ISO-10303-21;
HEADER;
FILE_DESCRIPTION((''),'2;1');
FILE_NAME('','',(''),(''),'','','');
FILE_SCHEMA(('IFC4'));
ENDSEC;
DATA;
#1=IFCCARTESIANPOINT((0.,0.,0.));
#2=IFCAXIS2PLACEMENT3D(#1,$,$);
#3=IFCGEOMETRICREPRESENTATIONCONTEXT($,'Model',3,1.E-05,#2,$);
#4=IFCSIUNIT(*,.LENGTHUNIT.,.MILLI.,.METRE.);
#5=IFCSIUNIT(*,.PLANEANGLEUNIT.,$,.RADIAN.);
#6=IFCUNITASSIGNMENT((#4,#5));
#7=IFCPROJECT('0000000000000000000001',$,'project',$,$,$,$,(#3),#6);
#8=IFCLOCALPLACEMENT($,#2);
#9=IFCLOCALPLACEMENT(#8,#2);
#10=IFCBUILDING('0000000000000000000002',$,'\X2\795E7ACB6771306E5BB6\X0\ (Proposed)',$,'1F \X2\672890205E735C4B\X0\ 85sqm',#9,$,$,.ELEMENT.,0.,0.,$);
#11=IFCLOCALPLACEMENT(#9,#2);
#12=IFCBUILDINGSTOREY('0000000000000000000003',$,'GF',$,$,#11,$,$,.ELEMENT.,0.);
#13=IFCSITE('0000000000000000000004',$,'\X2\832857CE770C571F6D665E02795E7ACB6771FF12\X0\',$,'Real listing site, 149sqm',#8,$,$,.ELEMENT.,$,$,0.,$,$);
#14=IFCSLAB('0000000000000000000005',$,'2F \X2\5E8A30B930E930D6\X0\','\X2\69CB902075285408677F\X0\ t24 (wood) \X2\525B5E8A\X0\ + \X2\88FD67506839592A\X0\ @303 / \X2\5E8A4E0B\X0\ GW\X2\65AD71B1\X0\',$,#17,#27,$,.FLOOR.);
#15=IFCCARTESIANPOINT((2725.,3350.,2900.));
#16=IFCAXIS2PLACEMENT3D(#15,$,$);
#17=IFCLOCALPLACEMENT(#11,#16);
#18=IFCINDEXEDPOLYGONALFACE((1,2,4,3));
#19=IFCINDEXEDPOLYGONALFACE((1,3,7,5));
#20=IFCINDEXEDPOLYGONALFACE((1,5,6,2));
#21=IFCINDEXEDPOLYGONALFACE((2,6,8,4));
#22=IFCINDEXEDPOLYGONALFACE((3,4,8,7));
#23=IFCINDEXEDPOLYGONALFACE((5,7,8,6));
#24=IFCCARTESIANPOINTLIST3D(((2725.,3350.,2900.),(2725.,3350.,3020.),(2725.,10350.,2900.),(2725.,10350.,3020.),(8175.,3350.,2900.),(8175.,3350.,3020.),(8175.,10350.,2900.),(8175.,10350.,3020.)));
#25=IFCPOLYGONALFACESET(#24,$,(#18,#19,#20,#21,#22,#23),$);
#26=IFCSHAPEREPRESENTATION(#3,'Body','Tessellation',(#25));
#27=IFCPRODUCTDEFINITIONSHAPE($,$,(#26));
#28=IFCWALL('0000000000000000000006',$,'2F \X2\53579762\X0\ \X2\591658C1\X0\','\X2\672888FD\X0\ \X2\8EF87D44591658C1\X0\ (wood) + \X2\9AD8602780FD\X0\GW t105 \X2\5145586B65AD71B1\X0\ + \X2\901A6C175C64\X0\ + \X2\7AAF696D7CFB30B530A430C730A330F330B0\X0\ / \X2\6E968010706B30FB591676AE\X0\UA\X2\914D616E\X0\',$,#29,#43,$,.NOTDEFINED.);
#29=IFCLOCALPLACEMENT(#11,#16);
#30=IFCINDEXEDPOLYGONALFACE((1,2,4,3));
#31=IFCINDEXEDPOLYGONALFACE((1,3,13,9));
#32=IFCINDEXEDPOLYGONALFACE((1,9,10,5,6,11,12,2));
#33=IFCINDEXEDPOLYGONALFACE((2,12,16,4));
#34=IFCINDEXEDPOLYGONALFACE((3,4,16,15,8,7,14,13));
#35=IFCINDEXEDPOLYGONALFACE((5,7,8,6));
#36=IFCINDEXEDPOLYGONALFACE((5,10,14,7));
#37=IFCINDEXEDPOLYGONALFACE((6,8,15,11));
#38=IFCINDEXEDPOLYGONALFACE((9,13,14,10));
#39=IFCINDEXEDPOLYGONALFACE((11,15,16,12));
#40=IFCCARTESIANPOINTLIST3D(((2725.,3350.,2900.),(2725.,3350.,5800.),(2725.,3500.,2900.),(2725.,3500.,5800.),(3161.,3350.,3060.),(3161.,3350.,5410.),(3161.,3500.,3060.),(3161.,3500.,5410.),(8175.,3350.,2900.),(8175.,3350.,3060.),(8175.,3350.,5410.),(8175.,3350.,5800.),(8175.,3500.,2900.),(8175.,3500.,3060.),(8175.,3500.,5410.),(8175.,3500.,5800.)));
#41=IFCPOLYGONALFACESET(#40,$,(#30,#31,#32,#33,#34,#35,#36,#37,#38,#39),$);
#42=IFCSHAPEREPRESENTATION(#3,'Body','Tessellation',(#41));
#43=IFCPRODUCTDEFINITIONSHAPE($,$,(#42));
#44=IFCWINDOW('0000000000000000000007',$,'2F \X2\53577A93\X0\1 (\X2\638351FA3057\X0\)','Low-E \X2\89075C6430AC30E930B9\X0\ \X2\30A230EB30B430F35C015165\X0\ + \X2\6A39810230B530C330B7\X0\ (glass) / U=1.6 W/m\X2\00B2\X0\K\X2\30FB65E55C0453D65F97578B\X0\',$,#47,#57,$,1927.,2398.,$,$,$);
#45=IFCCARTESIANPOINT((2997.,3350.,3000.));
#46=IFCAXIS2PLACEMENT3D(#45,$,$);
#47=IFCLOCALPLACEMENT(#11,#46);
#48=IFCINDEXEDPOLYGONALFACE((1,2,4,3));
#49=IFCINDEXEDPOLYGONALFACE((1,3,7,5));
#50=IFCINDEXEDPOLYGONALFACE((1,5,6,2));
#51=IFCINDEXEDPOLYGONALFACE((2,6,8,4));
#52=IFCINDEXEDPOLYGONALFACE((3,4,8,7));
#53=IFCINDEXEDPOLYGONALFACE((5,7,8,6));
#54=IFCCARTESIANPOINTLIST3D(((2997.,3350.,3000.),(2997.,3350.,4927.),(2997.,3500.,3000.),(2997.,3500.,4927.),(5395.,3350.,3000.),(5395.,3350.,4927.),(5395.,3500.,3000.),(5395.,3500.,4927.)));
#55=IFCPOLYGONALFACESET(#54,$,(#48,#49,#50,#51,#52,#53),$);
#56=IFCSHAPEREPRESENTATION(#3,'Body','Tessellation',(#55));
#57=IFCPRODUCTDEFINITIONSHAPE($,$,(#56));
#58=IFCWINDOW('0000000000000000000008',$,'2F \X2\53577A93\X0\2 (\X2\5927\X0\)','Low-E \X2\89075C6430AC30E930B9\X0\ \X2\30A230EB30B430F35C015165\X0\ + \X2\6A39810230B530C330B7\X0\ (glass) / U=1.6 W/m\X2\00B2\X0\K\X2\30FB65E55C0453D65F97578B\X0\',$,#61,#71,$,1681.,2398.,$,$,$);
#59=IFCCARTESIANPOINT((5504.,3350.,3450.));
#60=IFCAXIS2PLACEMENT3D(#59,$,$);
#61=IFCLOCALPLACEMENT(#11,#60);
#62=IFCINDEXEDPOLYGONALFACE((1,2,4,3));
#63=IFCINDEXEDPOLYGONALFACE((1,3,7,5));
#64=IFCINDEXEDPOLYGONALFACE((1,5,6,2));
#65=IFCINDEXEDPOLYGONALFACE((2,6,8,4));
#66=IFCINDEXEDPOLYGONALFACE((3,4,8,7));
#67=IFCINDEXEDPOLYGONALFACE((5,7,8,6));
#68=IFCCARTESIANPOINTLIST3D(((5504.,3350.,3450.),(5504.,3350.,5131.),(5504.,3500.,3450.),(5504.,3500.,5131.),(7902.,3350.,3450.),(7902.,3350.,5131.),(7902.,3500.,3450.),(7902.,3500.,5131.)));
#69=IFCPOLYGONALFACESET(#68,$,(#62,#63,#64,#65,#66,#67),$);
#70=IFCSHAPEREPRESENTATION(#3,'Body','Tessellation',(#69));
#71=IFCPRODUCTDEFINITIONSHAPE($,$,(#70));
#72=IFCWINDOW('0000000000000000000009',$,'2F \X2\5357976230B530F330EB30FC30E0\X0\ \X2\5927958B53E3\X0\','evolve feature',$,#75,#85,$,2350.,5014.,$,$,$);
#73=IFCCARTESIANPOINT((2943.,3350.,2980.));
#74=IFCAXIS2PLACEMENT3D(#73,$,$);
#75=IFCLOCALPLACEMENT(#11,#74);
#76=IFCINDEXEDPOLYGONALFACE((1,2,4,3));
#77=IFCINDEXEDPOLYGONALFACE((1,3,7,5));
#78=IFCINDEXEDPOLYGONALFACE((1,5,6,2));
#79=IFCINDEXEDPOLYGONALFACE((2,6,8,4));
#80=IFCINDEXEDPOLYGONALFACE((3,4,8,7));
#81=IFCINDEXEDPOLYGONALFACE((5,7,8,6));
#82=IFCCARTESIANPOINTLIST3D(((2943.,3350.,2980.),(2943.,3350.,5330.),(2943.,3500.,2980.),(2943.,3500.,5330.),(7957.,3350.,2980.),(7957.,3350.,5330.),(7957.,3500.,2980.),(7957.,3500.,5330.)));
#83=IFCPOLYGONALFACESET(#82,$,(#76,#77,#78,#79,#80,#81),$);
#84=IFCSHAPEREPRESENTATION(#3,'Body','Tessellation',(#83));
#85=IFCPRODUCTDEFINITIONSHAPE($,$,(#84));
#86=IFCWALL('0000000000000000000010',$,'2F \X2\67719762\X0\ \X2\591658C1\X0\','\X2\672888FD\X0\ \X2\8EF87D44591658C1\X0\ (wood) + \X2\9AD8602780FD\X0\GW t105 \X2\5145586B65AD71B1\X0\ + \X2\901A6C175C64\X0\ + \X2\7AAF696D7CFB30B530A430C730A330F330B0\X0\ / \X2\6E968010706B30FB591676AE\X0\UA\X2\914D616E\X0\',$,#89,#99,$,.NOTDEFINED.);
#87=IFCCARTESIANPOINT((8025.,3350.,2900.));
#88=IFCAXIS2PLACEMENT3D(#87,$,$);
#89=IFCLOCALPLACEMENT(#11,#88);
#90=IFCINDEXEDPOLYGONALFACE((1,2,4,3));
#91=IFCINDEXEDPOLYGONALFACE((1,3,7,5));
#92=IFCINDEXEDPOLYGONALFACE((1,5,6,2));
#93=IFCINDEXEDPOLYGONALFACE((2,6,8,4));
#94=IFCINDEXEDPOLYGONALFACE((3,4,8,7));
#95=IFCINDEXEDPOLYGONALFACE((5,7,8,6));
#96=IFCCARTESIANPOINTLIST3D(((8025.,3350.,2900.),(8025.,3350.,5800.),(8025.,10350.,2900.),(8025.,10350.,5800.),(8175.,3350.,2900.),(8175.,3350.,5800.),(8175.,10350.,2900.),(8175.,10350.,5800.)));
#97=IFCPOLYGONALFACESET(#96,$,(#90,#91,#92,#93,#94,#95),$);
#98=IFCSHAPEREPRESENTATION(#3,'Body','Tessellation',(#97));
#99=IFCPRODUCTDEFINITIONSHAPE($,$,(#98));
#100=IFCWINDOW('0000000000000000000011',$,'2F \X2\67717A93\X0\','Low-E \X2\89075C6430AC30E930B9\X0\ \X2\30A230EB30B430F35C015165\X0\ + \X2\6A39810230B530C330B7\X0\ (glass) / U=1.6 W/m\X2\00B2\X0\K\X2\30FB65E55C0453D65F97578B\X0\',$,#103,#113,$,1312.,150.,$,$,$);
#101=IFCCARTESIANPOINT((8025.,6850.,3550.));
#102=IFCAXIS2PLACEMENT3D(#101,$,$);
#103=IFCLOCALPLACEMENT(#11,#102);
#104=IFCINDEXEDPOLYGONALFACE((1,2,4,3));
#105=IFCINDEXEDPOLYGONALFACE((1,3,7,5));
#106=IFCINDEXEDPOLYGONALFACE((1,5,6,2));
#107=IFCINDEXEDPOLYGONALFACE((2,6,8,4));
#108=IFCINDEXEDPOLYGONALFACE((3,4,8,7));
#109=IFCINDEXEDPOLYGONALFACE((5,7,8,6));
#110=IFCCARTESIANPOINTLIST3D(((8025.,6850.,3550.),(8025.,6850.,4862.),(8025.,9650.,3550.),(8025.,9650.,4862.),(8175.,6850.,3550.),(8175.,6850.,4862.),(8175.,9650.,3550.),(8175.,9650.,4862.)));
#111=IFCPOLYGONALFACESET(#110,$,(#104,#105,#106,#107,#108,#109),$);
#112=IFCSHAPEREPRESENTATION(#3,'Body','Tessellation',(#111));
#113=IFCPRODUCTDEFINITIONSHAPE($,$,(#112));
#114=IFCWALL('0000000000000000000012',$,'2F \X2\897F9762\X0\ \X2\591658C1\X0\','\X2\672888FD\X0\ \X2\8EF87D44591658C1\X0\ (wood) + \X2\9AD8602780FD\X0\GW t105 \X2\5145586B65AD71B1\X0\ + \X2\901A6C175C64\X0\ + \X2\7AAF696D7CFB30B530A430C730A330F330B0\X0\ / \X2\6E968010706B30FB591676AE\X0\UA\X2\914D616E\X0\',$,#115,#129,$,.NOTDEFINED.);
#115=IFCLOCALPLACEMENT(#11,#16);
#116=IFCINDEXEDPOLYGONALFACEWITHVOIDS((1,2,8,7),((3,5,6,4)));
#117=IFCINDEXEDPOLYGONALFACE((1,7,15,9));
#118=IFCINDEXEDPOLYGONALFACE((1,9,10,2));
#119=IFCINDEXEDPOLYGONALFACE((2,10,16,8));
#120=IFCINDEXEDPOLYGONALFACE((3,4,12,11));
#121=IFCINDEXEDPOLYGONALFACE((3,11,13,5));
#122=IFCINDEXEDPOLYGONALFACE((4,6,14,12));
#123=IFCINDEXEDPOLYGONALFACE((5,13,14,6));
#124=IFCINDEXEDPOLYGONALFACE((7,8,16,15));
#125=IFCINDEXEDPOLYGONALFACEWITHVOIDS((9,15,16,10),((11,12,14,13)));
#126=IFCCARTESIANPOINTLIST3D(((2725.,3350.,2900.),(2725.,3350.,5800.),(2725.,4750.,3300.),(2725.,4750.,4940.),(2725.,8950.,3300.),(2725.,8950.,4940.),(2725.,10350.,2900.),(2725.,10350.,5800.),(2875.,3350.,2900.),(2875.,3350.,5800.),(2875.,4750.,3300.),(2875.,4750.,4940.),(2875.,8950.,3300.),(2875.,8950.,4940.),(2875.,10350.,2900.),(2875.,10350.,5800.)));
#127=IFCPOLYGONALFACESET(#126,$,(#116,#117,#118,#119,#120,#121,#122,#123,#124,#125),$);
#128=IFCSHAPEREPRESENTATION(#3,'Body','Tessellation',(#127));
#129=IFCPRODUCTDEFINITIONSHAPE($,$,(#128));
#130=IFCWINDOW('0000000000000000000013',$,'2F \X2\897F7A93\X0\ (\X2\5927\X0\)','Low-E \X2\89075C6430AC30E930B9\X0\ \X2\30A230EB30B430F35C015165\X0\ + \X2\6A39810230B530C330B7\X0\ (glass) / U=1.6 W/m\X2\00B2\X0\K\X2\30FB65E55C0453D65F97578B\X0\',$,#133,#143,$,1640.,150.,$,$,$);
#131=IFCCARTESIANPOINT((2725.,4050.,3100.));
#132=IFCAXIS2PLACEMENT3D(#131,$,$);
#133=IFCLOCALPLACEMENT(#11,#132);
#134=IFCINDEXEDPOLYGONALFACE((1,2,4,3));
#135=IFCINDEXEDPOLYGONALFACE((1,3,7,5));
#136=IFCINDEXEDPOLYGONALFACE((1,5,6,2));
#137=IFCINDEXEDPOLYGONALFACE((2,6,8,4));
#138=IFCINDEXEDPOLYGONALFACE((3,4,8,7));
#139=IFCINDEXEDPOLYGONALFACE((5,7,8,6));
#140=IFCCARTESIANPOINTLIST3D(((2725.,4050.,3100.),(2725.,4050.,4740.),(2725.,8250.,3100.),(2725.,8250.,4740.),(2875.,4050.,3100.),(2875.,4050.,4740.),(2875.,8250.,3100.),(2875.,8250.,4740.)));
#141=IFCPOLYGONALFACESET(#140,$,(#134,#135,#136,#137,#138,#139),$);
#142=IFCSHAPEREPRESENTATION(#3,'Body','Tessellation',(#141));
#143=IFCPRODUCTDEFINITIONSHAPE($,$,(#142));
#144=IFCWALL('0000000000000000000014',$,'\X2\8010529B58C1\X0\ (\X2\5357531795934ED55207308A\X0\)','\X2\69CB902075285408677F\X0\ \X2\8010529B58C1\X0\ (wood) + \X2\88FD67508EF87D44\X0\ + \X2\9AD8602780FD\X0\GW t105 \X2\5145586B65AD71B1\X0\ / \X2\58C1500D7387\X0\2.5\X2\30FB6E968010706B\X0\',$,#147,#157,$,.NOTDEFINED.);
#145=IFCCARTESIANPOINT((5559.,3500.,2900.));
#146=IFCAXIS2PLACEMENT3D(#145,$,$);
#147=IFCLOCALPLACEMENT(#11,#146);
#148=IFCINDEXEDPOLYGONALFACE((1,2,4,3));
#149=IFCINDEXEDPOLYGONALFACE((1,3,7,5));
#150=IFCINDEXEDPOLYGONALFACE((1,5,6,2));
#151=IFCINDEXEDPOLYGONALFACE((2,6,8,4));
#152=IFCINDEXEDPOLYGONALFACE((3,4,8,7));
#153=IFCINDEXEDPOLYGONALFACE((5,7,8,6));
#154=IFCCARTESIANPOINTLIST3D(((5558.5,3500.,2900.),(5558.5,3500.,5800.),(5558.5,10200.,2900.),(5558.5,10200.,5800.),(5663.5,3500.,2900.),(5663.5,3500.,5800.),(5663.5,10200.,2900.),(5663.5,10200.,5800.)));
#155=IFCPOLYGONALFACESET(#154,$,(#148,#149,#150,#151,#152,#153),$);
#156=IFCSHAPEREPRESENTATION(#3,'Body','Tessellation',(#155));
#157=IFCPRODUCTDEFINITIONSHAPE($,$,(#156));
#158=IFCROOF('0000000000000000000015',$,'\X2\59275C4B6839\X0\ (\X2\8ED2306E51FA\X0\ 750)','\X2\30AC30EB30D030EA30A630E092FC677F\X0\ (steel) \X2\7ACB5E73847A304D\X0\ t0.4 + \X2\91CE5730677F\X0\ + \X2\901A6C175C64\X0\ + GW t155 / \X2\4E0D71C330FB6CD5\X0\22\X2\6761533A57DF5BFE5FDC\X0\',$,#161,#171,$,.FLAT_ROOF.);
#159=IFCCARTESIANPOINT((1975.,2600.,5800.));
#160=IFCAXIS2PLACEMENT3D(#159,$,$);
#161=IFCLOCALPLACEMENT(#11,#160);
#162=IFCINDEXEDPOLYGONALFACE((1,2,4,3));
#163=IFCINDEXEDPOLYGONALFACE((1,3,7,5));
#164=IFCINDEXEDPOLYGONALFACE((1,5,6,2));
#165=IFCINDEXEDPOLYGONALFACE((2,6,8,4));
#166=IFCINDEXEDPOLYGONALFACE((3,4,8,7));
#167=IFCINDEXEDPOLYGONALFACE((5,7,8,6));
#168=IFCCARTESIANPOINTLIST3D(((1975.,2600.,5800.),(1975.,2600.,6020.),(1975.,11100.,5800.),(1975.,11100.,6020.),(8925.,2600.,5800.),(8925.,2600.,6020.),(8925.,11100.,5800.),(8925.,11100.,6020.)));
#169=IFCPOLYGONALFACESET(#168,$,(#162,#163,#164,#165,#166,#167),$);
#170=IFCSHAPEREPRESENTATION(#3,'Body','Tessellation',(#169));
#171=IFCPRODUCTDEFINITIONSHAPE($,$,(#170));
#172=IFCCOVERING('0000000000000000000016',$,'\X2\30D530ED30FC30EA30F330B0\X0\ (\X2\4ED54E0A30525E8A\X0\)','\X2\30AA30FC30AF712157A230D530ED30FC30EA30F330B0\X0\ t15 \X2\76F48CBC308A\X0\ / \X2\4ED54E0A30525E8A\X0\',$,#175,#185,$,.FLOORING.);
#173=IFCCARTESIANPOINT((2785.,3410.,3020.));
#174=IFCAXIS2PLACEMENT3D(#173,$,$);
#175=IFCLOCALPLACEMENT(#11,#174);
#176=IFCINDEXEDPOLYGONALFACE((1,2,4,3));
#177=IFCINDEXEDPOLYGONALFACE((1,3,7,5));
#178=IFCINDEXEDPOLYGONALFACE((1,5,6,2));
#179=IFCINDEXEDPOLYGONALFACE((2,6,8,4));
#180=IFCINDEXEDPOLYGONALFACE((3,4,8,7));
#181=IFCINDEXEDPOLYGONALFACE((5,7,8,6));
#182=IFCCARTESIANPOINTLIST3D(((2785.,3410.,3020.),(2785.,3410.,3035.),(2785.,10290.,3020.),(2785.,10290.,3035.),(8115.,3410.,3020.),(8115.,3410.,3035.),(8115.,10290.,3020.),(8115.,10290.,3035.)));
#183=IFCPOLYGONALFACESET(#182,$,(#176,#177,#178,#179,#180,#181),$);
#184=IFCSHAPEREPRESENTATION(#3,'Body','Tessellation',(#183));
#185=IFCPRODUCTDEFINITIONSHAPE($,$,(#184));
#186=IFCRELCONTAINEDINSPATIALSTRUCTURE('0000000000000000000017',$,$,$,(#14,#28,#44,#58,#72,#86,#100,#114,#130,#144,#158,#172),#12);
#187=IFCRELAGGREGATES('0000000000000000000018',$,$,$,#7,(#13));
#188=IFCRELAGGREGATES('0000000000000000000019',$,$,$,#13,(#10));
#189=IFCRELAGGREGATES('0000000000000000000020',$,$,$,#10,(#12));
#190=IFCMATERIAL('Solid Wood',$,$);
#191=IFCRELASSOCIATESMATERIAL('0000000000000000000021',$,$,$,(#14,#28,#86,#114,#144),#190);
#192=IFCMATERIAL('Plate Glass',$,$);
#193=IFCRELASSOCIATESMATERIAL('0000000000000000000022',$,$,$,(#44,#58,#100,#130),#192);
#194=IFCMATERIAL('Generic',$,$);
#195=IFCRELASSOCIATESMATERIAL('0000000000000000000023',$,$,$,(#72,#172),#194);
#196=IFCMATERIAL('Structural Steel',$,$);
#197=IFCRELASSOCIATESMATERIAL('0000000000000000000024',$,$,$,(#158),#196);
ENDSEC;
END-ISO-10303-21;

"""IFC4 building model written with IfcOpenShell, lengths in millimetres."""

from ifc_helpers import new_model, si_unit, frame, frame_2d, origin, place, context, project, spatial, rectangle, extrude, material, element, fill, save


model = new_model("IFC4")

# Units and contexts
model_context = context("Model", 3, precision=1e-05, world=origin())
ifc_project = project(units=[si_unit("LENGTHUNIT", "METRE", prefix="MILLI"), si_unit("PLANEANGLEUNIT", "RADIAN")], contexts=[model_context])

# Site, building, storey
site_placement = place(None, origin())
site = spatial("IfcSite", under=ifc_project, at=site_placement, Name="茨城県土浦市神立東２", ObjectType="Real listing site, 149sqm", CompositionType="ELEMENT", RefElevation=0.0)
building_placement = place(site_placement, origin())
building = spatial("IfcBuilding", under=site, at=building_placement, Name="神立東の家 (Proposed)", ObjectType="1F 木造平屋 85sqm", CompositionType="ELEMENT", ElevationOfRefHeight=0.0, ElevationOfTerrain=0.0)
storey_placement = place(building_placement, origin())
storey = spatial("IfcBuildingStorey", under=building, at=storey_placement, Name="GF", CompositionType="ELEMENT", Elevation=0.0)

# Slab
ifc_material_1 = material(Name="Solid Wood")
slab_placement = place(storey_placement, frame((2725.0, 3350.0, 2900.0)))
element("IfcSlab", 1, at=slab_placement, inside=storey, material=ifc_material_1, Name="2F 床スラブ", Description="構造用合板 t24 (wood) 剛床 + 製材根太 @303 / 床下 GW断熱", PredefinedType="FLOOR", context=model_context, shape_type="SweptSolid", body=[
    extrude(rectangle(XDim=5450.0, YDim=7000.0, at=frame_2d((2725.0, 3500.0))), frame((2725.0, 3350.0, 2900.0)), (0.0, 0.0, 1.0), 120.0),
])

# Wall, openings, windows
wall_1_placement = place(storey_placement, frame((2725.0, 3350.0, 2900.0)))
wall_1 = element("IfcWall", 2, at=wall_1_placement, inside=storey, material=ifc_material_1, Name="2F 南面 外壁", Description="木製 軸組外壁 (wood) + 高性能GW t105 充填断熱 + 通気層 + 窯業系サイディング / 準耐火・外皮UA配慮", PredefinedType="NOTDEFINED", context=model_context, shape_type="SweptSolid", body=[
    extrude(rectangle(XDim=5450.0, YDim=150.0, at=frame_2d((2725.0, 75.0))), frame((2725.0, 3350.0, 2900.0)), (0.0, 0.0, 1.0), 2900.0),
])
opening_1_placement = place(storey_placement, frame((2997.0, 3350.0, 3000.0)))
opening_1 = element("IfcOpeningElement", 3, at=opening_1_placement, cuts=wall_1, PredefinedType="NOTDEFINED", context=model_context, shape_type="SweptSolid", body=[
    extrude(rectangle(XDim=2398.0, YDim=150.0, at=frame_2d((1199.0, 75.0))), frame((2997.0, 3350.0, 3000.0)), (0.0, 0.0, 1.0), 1927.0),
])
opening_2_placement = place(storey_placement, frame((5504.0, 3350.0, 3450.0)))
opening_2 = element("IfcOpeningElement", 4, at=opening_2_placement, cuts=wall_1, PredefinedType="NOTDEFINED", context=model_context, shape_type="SweptSolid", body=[
    extrude(rectangle(XDim=2398.0, YDim=150.0, at=frame_2d((1199.0, 75.0))), frame((5504.0, 3350.0, 3450.0)), (0.0, 0.0, 1.0), 1681.0),
])
opening_3_placement = place(storey_placement, frame((2943.0, 3350.0, 2980.0)))
opening_3 = element("IfcOpeningElement", 5, at=opening_3_placement, cuts=wall_1, PredefinedType="NOTDEFINED", context=model_context, shape_type="SweptSolid", body=[
    extrude(rectangle(XDim=5014.0, YDim=150.0, at=frame_2d((2507.0, 75.0))), frame((2943.0, 3350.0, 2980.0)), (0.0, 0.0, 1.0), 2350.0),
])
ifc_material_2 = material(Name="Plate Glass")
window_1_placement = place(storey_placement, frame((2997.0, 3350.0, 3000.0)))
window_1 = element("IfcWindow", 6, at=window_1_placement, inside=storey, material=ifc_material_2, Name="2F 南窓1 (掃出し)", Description="Low-E 複層ガラス アルゴン封入 + 樹脂サッシ (glass) / U=1.6 W/m²K・日射取得型", OverallHeight=1927.0, OverallWidth=2398.0, context=model_context, shape_type="SweptSolid", body=[
    extrude(rectangle(XDim=2398.0, YDim=150.0, at=frame_2d((1199.0, 75.0))), frame((2997.0, 3350.0, 3000.0)), (0.0, 0.0, 1.0), 1927.0),
])
fill(opening_1, window_1)
window_2_placement = place(storey_placement, frame((5504.0, 3350.0, 3450.0)))
window_2 = element("IfcWindow", 7, at=window_2_placement, inside=storey, material=ifc_material_2, Name="2F 南窓2 (大)", Description="Low-E 複層ガラス アルゴン封入 + 樹脂サッシ (glass) / U=1.6 W/m²K・日射取得型", OverallHeight=1681.0, OverallWidth=2398.0, context=model_context, shape_type="SweptSolid", body=[
    extrude(rectangle(XDim=2398.0, YDim=150.0, at=frame_2d((1199.0, 75.0))), frame((5504.0, 3350.0, 3450.0)), (0.0, 0.0, 1.0), 1681.0),
])
fill(opening_2, window_2)
ifc_material_3 = material(Name="Generic")
window_3_placement = place(storey_placement, frame((2943.0, 3350.0, 2980.0)))
window_3 = element("IfcWindow", 8, at=window_3_placement, inside=storey, material=ifc_material_3, Name="2F 南面サンルーム 大開口", Description="evolve feature", OverallHeight=2350.0, OverallWidth=5014.0, context=model_context, shape_type="SweptSolid", body=[
    extrude(rectangle(XDim=5014.0, YDim=150.0, at=frame_2d((2507.0, 75.0))), frame((2943.0, 3350.0, 2980.0)), (0.0, 0.0, 1.0), 2350.0),
])
fill(opening_3, window_3)

# Walls, openings, windows
wall_2_placement = place(storey_placement, frame((8025.0, 3350.0, 2900.0)))
wall_2 = element("IfcWall", 9, at=wall_2_placement, inside=storey, material=ifc_material_1, Name="2F 東面 外壁", Description="木製 軸組外壁 (wood) + 高性能GW t105 充填断熱 + 通気層 + 窯業系サイディング / 準耐火・外皮UA配慮", PredefinedType="NOTDEFINED", context=model_context, shape_type="SweptSolid", body=[
    extrude(rectangle(XDim=150.0, YDim=7000.0, at=frame_2d((75.0, 3500.0))), frame((8025.0, 3350.0, 2900.0)), (0.0, 0.0, 1.0), 2900.0),
])
opening_4_placement = place(storey_placement, frame((8025.0, 6850.0, 3550.0)))
opening_4 = element("IfcOpeningElement", 10, at=opening_4_placement, cuts=wall_2, PredefinedType="NOTDEFINED", context=model_context, shape_type="SweptSolid", body=[
    extrude(rectangle(XDim=150.0, YDim=2800.0, at=frame_2d((75.0, 1400.0))), frame((8025.0, 6850.0, 3550.0)), (0.0, 0.0, 1.0), 1312.0),
])
window_4_placement = place(storey_placement, frame((8025.0, 6850.0, 3550.0)))
window_4 = element("IfcWindow", 11, at=window_4_placement, inside=storey, material=ifc_material_2, Name="2F 東窓", Description="Low-E 複層ガラス アルゴン封入 + 樹脂サッシ (glass) / U=1.6 W/m²K・日射取得型", OverallHeight=1312.0, OverallWidth=150.0, context=model_context, shape_type="SweptSolid", body=[
    extrude(rectangle(XDim=150.0, YDim=2800.0, at=frame_2d((75.0, 1400.0))), frame((8025.0, 6850.0, 3550.0)), (0.0, 0.0, 1.0), 1312.0),
])
fill(opening_4, window_4)
wall_3_placement = place(storey_placement, frame((2725.0, 3350.0, 2900.0)))
wall_3 = element("IfcWall", 12, at=wall_3_placement, inside=storey, material=ifc_material_1, Name="2F 西面 外壁", Description="木製 軸組外壁 (wood) + 高性能GW t105 充填断熱 + 通気層 + 窯業系サイディング / 準耐火・外皮UA配慮", PredefinedType="NOTDEFINED", context=model_context, shape_type="SweptSolid", body=[
    extrude(rectangle(XDim=150.0, YDim=7000.0, at=frame_2d((75.0, 3500.0))), frame((2725.0, 3350.0, 2900.0)), (0.0, 0.0, 1.0), 2900.0),
])
opening_5_placement = place(storey_placement, frame((2725.0, 4050.0, 3100.0)))
opening_5 = element("IfcOpeningElement", 13, at=opening_5_placement, cuts=wall_3, PredefinedType="NOTDEFINED", context=model_context, shape_type="SweptSolid", body=[
    extrude(rectangle(XDim=150.0, YDim=4200.0, at=frame_2d((75.0, 2100.0))), frame((2725.0, 4050.0, 3100.0)), (0.0, 0.0, 1.0), 1640.0),
])
window_5_placement = place(storey_placement, frame((2725.0, 4050.0, 3100.0)))
window_5 = element("IfcWindow", 14, at=window_5_placement, inside=storey, material=ifc_material_2, Name="2F 西窓 (大)", Description="Low-E 複層ガラス アルゴン封入 + 樹脂サッシ (glass) / U=1.6 W/m²K・日射取得型", OverallHeight=1640.0, OverallWidth=150.0, context=model_context, shape_type="SweptSolid", body=[
    extrude(rectangle(XDim=150.0, YDim=4200.0, at=frame_2d((75.0, 2100.0))), frame((2725.0, 4050.0, 3100.0)), (0.0, 0.0, 1.0), 1640.0),
])
fill(opening_5, window_5)

# Wall
wall_4_placement = place(storey_placement, frame((5559.0, 3500.0, 2900.0)))
element("IfcWall", 15, at=wall_4_placement, inside=storey, material=ifc_material_1, Name="耐力壁 (南北間仕切り)", Description="構造用合板 耐力壁 (wood) + 製材軸組 + 高性能GW t105 充填断熱 / 壁倍率2.5・準耐火", PredefinedType="NOTDEFINED", context=model_context, shape_type="SweptSolid", body=[
    extrude(rectangle(XDim=105.0, YDim=6700.0, at=frame_2d((52.0, 3350.0))), frame((5559.0, 3500.0, 2900.0)), (0.0, 0.0, 1.0), 2900.0),
])

# Roof
ifc_material_4 = material(Name="Structural Steel")
roof_placement = place(storey_placement, frame((1975.0, 2600.0, 5800.0)))
element("IfcRoof", 16, at=roof_placement, inside=storey, material=ifc_material_4, Name="大屋根 (軒の出 750)", Description="ガルバリウム鋼板 (steel) 立平葺き t0.4 + 野地板 + 通気層 + GW t155 / 不燃・法22条区域対応", PredefinedType="FLAT_ROOF", context=model_context, shape_type="SweptSolid", body=[
    extrude(rectangle(XDim=6950.0, YDim=8500.0, at=frame_2d((3475.0, 4250.0))), frame((1975.0, 2600.0, 5800.0)), (0.0, 0.0, 1.0), 220.0),
])

# Covering
covering_placement = place(storey_placement, frame((2785.0, 3410.0, 3020.0)))
element("IfcCovering", 17, at=covering_placement, inside=storey, material=ifc_material_3, Name="フローリング (仕上げ床)", Description="オーク無垢フローリング t15 直貼り / 仕上げ床", PredefinedType="FLOORING", context=model_context, shape_type="SweptSolid", body=[
    extrude(rectangle(XDim=5330.0, YDim=6880.0, at=frame_2d((2665.0, 3440.0))), frame((2785.0, 3410.0, 3020.0)), (0.0, 0.0, 1.0), 15.0),
])

save(model, "model.ifc")
